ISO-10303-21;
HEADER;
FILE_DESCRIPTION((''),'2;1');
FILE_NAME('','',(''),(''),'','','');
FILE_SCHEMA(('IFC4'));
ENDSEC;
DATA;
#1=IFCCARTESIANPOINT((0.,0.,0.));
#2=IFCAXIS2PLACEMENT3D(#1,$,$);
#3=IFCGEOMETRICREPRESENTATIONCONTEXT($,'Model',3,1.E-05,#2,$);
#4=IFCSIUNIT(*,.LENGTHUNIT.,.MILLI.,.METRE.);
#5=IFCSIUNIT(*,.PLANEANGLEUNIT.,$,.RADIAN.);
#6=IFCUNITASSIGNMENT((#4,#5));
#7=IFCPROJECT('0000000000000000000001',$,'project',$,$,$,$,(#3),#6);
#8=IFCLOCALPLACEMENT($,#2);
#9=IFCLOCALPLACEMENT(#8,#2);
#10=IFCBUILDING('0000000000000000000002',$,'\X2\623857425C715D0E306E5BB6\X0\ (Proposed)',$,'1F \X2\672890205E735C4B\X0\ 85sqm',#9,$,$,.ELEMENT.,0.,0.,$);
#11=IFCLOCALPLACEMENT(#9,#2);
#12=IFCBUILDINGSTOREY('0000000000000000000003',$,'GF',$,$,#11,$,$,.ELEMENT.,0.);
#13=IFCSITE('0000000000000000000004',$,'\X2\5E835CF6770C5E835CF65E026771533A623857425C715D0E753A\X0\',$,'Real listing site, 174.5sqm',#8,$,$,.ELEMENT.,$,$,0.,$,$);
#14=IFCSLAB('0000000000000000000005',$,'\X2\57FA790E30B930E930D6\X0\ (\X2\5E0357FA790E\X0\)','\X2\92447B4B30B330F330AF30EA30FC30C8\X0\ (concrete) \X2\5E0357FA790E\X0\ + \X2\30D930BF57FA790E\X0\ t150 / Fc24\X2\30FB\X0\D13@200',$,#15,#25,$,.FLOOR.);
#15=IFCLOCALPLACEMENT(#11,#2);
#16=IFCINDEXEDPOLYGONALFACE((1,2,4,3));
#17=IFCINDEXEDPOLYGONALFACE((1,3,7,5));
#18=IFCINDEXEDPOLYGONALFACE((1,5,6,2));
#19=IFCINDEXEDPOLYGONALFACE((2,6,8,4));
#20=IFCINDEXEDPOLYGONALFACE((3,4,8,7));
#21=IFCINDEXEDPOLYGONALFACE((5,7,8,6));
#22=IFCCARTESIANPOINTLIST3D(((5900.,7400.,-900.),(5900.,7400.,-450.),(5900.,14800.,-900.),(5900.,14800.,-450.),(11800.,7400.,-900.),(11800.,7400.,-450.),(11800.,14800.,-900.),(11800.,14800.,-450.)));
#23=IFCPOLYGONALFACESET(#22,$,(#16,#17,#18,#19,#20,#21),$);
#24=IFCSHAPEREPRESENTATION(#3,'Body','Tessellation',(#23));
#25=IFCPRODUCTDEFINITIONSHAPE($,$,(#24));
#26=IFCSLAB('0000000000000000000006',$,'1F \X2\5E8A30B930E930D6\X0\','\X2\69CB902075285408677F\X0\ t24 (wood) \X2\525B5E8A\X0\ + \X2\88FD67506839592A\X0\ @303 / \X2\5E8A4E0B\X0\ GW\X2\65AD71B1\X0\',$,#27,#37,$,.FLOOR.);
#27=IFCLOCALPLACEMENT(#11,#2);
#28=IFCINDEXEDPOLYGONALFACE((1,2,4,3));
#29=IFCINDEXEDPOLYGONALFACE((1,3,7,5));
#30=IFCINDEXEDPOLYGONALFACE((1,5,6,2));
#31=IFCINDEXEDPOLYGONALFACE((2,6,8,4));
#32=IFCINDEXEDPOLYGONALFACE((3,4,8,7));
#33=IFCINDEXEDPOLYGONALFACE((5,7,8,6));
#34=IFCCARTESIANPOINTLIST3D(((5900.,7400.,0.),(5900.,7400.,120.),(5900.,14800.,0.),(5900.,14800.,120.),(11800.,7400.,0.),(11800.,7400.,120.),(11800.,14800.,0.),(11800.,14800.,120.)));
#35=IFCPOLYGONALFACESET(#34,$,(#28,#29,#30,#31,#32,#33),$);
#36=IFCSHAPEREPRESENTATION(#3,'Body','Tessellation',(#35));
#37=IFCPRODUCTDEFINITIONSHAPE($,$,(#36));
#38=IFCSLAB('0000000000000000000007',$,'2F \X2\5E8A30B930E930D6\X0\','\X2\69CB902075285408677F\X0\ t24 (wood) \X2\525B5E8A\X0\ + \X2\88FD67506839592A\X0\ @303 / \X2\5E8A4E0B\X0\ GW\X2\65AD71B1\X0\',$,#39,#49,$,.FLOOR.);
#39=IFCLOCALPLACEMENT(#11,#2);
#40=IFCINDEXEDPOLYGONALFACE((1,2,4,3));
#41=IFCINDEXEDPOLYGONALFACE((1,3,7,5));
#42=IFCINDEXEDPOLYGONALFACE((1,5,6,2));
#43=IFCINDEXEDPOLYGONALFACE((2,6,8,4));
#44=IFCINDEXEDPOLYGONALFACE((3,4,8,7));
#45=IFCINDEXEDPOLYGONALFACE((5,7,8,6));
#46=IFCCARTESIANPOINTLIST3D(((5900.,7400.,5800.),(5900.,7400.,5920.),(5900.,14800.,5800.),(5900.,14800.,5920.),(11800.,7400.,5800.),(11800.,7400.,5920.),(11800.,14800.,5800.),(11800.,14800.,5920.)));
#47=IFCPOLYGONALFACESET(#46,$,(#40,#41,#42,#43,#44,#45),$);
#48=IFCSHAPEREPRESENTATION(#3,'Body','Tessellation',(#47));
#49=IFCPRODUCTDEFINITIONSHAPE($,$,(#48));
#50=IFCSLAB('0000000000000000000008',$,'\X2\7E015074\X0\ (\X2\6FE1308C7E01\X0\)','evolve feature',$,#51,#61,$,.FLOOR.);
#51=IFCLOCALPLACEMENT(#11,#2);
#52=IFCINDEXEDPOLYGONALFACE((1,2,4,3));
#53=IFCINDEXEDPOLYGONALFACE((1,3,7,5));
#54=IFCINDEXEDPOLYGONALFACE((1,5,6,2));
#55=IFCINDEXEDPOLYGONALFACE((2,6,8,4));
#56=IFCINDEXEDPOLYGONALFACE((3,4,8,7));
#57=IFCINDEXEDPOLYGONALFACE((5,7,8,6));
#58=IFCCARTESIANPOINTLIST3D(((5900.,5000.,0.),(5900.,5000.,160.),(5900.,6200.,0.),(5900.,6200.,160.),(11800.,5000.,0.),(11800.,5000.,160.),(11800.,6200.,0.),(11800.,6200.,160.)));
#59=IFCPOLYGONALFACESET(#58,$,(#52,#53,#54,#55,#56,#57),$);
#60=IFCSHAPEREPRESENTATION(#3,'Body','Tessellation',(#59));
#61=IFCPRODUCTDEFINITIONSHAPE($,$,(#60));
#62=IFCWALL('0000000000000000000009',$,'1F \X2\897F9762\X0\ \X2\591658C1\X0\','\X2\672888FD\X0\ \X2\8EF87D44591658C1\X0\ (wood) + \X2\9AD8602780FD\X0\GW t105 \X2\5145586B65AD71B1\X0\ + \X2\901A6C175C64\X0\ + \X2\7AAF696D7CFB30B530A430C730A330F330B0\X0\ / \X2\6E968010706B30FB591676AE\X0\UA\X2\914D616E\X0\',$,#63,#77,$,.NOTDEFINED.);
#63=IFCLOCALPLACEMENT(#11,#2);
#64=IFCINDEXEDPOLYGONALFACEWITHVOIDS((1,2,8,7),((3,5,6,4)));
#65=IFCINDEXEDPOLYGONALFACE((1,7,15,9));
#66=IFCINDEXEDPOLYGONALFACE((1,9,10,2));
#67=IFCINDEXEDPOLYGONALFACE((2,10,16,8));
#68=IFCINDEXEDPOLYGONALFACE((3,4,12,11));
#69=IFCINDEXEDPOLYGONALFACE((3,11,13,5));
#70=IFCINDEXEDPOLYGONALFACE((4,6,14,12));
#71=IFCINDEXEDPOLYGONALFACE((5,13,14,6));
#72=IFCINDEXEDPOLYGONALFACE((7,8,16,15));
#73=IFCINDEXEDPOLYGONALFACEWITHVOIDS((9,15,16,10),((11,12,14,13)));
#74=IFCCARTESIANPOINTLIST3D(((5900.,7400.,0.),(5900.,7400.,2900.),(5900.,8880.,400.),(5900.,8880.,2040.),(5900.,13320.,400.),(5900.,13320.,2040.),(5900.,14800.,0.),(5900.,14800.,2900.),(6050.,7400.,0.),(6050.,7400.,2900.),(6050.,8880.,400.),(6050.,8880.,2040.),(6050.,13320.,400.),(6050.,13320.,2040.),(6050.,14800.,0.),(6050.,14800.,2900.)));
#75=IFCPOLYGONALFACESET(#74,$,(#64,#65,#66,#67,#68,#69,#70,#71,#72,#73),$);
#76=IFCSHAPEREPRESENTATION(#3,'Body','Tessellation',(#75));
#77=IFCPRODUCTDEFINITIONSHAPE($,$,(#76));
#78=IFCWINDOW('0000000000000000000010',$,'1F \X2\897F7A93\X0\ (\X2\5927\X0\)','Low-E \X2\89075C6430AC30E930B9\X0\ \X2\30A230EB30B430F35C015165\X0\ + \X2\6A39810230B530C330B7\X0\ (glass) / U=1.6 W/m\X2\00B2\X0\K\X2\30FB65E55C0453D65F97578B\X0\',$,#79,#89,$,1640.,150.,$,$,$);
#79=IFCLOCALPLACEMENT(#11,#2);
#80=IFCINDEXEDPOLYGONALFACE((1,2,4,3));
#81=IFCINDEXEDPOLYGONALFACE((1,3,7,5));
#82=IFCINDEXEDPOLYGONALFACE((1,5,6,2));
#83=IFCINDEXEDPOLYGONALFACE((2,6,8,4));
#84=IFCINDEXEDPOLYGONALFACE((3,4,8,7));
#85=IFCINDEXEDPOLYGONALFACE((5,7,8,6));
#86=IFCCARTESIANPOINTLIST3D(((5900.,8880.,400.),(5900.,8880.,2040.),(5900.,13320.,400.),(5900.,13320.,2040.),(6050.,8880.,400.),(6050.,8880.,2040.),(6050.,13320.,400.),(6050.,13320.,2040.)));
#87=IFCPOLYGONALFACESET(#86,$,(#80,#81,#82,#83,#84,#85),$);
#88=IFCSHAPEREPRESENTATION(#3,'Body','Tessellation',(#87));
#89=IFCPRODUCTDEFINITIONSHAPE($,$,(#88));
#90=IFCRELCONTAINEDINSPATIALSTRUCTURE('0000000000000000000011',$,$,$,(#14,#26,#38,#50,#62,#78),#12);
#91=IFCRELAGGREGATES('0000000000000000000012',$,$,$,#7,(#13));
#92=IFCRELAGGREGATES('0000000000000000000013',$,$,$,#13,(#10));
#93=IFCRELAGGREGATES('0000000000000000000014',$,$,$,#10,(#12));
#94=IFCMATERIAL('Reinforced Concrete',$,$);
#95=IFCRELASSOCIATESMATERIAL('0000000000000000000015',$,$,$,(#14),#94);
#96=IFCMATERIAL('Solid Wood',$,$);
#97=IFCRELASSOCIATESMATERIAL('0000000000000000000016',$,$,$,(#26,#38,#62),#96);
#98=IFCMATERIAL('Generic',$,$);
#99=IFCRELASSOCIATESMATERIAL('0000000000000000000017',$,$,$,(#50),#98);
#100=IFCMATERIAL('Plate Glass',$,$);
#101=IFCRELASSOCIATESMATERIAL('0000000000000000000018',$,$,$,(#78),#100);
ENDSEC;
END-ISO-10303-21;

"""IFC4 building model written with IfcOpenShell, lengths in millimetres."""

from ifc_helpers import new_model, si_unit, frame, frame_2d, origin, place, context, project, spatial, rectangle, extrude, material, element, fill, save


model = new_model("IFC4")

# Units and contexts
model_context = context("Model", 3, precision=1e-05, world=origin())
ifc_project = project(units=[si_unit("LENGTHUNIT", "METRE", prefix="MILLI"), si_unit("PLANEANGLEUNIT", "RADIAN")], contexts=[model_context])

# Site, building, storey
site_placement = place(None, origin())
site = spatial("IfcSite", under=ifc_project, at=site_placement, Name="広島県広島市東区戸坂山崎町", ObjectType="Real listing site, 174.5sqm", CompositionType="ELEMENT", RefElevation=0.0)
building_placement = place(site_placement, origin())
building = spatial("IfcBuilding", under=site, at=building_placement, Name="戸坂山崎の家 (Proposed)", ObjectType="1F 木造平屋 85sqm", CompositionType="ELEMENT", ElevationOfRefHeight=0.0, ElevationOfTerrain=0.0)
storey_placement = place(building_placement, origin())
storey = spatial("IfcBuildingStorey", under=building, at=storey_placement, Name="GF", CompositionType="ELEMENT", Elevation=0.0)

# Slabs
ifc_material_1 = material(Name="Reinforced Concrete")
slab_1_placement = place(storey_placement, frame((2950.0, 3700.0, -450.0)))
element("IfcSlab", 1, at=slab_1_placement, inside=storey, material=ifc_material_1, Name="基礎スラブ (布基礎)", Description="鉄筋コンクリート (concrete) 布基礎 + ベタ基礎 t150 / Fc24・D13@200", PredefinedType="FLOOR", context=model_context, shape_type="SweptSolid", body=[
    extrude(rectangle(XDim=5900.0, YDim=7400.0, at=frame_2d((2950.0, 3700.0))), frame((2950.0, 3700.0, -450.0)), (0.0, 0.0, 1.0), 450.0),
])
ifc_material_2 = material(Name="Solid Wood")
slab_2_placement = place(storey_placement, frame((2950.0, 3700.0, 0.0)))
element("IfcSlab", 2, at=slab_2_placement, inside=storey, material=ifc_material_2, Name="1F 床スラブ", Description="構造用合板 t24 (wood) 剛床 + 製材根太 @303 / 床下 GW断熱", PredefinedType="FLOOR", context=model_context, shape_type="SweptSolid", body=[
    extrude(rectangle(XDim=5900.0, YDim=7400.0, at=frame_2d((2950.0, 3700.0))), frame((2950.0, 3700.0, 0.0)), (0.0, 0.0, 1.0), 120.0),
])
slab_3_placement = place(storey_placement, frame((2950.0, 3700.0, 2900.0)))
element("IfcSlab", 3, at=slab_3_placement, inside=storey, material=ifc_material_2, Name="2F 床スラブ", Description="構造用合板 t24 (wood) 剛床 + 製材根太 @303 / 床下 GW断熱", PredefinedType="FLOOR", context=model_context, shape_type="SweptSolid", body=[
    extrude(rectangle(XDim=5900.0, YDim=7400.0, at=frame_2d((2950.0, 3700.0))), frame((2950.0, 3700.0, 2900.0)), (0.0, 0.0, 1.0), 120.0),
])
ifc_material_3 = material(Name="Generic")
slab_4_placement = place(storey_placement, frame((2950.0, 2500.0, 0.0)))
element("IfcSlab", 4, at=slab_4_placement, inside=storey, material=ifc_material_3, Name="縁側 (濡れ縁)", Description="evolve feature", PredefinedType="FLOOR", context=model_context, shape_type="SweptSolid", body=[
    extrude(rectangle(XDim=5900.0, YDim=1200.0, at=frame_2d((2950.0, 600.0))), frame((2950.0, 2500.0, 0.0)), (0.0, 0.0, 1.0), 160.0),
])

# Shared definitions
ifc_material_4 = material(Name="Plate Glass")

# Wall, opening, window
wall_1_placement = place(storey_placement, frame((2950.0, 3700.0, 0.0)))
wall_1 = element("IfcWall", 5, at=wall_1_placement, inside=storey, material=ifc_material_2, Name="1F 西面 外壁", Description="木製 軸組外壁 (wood) + 高性能GW t105 充填断熱 + 通気層 + 窯業系サイディング / 準耐火・外皮UA配慮", PredefinedType="NOTDEFINED", context=model_context, shape_type="SweptSolid", body=[
    extrude(rectangle(XDim=150.0, YDim=7400.0, at=frame_2d((75.0, 3700.0))), frame((2950.0, 3700.0, 0.0)), (0.0, 0.0, 1.0), 2900.0),
])
opening_1_placement = place(storey_placement, frame((2950.0, 4440.0, 200.0)))
opening_1 = element("IfcOpeningElement", 6, at=opening_1_placement, cuts=wall_1, PredefinedType="NOTDEFINED", context=model_context, shape_type="SweptSolid", body=[
    extrude(rectangle(XDim=150.0, YDim=4440.0, at=frame_2d((75.0, 2220.0))), frame((2950.0, 4440.0, 200.0)), (0.0, 0.0, 1.0), 1640.0),
])
window_1_placement = place(storey_placement, frame((2950.0, 4440.0, 200.0)))
window_1 = element("IfcWindow", 7, at=window_1_placement, inside=storey, material=ifc_material_4, Name="1F 西窓 (大)", Description="Low-E 複層ガラス アルゴン封入 + 樹脂サッシ (glass) / U=1.6 W/m²K・日射取得型", OverallHeight=1640.0, OverallWidth=150.0, context=model_context, shape_type="SweptSolid", body=[
    extrude(rectangle(XDim=150.0, YDim=4440.0, at=frame_2d((75.0, 2220.0))), frame((2950.0, 4440.0, 200.0)), (0.0, 0.0, 1.0), 1640.0),
])
fill(opening_1, window_1)

save(model, "model.ifc")
